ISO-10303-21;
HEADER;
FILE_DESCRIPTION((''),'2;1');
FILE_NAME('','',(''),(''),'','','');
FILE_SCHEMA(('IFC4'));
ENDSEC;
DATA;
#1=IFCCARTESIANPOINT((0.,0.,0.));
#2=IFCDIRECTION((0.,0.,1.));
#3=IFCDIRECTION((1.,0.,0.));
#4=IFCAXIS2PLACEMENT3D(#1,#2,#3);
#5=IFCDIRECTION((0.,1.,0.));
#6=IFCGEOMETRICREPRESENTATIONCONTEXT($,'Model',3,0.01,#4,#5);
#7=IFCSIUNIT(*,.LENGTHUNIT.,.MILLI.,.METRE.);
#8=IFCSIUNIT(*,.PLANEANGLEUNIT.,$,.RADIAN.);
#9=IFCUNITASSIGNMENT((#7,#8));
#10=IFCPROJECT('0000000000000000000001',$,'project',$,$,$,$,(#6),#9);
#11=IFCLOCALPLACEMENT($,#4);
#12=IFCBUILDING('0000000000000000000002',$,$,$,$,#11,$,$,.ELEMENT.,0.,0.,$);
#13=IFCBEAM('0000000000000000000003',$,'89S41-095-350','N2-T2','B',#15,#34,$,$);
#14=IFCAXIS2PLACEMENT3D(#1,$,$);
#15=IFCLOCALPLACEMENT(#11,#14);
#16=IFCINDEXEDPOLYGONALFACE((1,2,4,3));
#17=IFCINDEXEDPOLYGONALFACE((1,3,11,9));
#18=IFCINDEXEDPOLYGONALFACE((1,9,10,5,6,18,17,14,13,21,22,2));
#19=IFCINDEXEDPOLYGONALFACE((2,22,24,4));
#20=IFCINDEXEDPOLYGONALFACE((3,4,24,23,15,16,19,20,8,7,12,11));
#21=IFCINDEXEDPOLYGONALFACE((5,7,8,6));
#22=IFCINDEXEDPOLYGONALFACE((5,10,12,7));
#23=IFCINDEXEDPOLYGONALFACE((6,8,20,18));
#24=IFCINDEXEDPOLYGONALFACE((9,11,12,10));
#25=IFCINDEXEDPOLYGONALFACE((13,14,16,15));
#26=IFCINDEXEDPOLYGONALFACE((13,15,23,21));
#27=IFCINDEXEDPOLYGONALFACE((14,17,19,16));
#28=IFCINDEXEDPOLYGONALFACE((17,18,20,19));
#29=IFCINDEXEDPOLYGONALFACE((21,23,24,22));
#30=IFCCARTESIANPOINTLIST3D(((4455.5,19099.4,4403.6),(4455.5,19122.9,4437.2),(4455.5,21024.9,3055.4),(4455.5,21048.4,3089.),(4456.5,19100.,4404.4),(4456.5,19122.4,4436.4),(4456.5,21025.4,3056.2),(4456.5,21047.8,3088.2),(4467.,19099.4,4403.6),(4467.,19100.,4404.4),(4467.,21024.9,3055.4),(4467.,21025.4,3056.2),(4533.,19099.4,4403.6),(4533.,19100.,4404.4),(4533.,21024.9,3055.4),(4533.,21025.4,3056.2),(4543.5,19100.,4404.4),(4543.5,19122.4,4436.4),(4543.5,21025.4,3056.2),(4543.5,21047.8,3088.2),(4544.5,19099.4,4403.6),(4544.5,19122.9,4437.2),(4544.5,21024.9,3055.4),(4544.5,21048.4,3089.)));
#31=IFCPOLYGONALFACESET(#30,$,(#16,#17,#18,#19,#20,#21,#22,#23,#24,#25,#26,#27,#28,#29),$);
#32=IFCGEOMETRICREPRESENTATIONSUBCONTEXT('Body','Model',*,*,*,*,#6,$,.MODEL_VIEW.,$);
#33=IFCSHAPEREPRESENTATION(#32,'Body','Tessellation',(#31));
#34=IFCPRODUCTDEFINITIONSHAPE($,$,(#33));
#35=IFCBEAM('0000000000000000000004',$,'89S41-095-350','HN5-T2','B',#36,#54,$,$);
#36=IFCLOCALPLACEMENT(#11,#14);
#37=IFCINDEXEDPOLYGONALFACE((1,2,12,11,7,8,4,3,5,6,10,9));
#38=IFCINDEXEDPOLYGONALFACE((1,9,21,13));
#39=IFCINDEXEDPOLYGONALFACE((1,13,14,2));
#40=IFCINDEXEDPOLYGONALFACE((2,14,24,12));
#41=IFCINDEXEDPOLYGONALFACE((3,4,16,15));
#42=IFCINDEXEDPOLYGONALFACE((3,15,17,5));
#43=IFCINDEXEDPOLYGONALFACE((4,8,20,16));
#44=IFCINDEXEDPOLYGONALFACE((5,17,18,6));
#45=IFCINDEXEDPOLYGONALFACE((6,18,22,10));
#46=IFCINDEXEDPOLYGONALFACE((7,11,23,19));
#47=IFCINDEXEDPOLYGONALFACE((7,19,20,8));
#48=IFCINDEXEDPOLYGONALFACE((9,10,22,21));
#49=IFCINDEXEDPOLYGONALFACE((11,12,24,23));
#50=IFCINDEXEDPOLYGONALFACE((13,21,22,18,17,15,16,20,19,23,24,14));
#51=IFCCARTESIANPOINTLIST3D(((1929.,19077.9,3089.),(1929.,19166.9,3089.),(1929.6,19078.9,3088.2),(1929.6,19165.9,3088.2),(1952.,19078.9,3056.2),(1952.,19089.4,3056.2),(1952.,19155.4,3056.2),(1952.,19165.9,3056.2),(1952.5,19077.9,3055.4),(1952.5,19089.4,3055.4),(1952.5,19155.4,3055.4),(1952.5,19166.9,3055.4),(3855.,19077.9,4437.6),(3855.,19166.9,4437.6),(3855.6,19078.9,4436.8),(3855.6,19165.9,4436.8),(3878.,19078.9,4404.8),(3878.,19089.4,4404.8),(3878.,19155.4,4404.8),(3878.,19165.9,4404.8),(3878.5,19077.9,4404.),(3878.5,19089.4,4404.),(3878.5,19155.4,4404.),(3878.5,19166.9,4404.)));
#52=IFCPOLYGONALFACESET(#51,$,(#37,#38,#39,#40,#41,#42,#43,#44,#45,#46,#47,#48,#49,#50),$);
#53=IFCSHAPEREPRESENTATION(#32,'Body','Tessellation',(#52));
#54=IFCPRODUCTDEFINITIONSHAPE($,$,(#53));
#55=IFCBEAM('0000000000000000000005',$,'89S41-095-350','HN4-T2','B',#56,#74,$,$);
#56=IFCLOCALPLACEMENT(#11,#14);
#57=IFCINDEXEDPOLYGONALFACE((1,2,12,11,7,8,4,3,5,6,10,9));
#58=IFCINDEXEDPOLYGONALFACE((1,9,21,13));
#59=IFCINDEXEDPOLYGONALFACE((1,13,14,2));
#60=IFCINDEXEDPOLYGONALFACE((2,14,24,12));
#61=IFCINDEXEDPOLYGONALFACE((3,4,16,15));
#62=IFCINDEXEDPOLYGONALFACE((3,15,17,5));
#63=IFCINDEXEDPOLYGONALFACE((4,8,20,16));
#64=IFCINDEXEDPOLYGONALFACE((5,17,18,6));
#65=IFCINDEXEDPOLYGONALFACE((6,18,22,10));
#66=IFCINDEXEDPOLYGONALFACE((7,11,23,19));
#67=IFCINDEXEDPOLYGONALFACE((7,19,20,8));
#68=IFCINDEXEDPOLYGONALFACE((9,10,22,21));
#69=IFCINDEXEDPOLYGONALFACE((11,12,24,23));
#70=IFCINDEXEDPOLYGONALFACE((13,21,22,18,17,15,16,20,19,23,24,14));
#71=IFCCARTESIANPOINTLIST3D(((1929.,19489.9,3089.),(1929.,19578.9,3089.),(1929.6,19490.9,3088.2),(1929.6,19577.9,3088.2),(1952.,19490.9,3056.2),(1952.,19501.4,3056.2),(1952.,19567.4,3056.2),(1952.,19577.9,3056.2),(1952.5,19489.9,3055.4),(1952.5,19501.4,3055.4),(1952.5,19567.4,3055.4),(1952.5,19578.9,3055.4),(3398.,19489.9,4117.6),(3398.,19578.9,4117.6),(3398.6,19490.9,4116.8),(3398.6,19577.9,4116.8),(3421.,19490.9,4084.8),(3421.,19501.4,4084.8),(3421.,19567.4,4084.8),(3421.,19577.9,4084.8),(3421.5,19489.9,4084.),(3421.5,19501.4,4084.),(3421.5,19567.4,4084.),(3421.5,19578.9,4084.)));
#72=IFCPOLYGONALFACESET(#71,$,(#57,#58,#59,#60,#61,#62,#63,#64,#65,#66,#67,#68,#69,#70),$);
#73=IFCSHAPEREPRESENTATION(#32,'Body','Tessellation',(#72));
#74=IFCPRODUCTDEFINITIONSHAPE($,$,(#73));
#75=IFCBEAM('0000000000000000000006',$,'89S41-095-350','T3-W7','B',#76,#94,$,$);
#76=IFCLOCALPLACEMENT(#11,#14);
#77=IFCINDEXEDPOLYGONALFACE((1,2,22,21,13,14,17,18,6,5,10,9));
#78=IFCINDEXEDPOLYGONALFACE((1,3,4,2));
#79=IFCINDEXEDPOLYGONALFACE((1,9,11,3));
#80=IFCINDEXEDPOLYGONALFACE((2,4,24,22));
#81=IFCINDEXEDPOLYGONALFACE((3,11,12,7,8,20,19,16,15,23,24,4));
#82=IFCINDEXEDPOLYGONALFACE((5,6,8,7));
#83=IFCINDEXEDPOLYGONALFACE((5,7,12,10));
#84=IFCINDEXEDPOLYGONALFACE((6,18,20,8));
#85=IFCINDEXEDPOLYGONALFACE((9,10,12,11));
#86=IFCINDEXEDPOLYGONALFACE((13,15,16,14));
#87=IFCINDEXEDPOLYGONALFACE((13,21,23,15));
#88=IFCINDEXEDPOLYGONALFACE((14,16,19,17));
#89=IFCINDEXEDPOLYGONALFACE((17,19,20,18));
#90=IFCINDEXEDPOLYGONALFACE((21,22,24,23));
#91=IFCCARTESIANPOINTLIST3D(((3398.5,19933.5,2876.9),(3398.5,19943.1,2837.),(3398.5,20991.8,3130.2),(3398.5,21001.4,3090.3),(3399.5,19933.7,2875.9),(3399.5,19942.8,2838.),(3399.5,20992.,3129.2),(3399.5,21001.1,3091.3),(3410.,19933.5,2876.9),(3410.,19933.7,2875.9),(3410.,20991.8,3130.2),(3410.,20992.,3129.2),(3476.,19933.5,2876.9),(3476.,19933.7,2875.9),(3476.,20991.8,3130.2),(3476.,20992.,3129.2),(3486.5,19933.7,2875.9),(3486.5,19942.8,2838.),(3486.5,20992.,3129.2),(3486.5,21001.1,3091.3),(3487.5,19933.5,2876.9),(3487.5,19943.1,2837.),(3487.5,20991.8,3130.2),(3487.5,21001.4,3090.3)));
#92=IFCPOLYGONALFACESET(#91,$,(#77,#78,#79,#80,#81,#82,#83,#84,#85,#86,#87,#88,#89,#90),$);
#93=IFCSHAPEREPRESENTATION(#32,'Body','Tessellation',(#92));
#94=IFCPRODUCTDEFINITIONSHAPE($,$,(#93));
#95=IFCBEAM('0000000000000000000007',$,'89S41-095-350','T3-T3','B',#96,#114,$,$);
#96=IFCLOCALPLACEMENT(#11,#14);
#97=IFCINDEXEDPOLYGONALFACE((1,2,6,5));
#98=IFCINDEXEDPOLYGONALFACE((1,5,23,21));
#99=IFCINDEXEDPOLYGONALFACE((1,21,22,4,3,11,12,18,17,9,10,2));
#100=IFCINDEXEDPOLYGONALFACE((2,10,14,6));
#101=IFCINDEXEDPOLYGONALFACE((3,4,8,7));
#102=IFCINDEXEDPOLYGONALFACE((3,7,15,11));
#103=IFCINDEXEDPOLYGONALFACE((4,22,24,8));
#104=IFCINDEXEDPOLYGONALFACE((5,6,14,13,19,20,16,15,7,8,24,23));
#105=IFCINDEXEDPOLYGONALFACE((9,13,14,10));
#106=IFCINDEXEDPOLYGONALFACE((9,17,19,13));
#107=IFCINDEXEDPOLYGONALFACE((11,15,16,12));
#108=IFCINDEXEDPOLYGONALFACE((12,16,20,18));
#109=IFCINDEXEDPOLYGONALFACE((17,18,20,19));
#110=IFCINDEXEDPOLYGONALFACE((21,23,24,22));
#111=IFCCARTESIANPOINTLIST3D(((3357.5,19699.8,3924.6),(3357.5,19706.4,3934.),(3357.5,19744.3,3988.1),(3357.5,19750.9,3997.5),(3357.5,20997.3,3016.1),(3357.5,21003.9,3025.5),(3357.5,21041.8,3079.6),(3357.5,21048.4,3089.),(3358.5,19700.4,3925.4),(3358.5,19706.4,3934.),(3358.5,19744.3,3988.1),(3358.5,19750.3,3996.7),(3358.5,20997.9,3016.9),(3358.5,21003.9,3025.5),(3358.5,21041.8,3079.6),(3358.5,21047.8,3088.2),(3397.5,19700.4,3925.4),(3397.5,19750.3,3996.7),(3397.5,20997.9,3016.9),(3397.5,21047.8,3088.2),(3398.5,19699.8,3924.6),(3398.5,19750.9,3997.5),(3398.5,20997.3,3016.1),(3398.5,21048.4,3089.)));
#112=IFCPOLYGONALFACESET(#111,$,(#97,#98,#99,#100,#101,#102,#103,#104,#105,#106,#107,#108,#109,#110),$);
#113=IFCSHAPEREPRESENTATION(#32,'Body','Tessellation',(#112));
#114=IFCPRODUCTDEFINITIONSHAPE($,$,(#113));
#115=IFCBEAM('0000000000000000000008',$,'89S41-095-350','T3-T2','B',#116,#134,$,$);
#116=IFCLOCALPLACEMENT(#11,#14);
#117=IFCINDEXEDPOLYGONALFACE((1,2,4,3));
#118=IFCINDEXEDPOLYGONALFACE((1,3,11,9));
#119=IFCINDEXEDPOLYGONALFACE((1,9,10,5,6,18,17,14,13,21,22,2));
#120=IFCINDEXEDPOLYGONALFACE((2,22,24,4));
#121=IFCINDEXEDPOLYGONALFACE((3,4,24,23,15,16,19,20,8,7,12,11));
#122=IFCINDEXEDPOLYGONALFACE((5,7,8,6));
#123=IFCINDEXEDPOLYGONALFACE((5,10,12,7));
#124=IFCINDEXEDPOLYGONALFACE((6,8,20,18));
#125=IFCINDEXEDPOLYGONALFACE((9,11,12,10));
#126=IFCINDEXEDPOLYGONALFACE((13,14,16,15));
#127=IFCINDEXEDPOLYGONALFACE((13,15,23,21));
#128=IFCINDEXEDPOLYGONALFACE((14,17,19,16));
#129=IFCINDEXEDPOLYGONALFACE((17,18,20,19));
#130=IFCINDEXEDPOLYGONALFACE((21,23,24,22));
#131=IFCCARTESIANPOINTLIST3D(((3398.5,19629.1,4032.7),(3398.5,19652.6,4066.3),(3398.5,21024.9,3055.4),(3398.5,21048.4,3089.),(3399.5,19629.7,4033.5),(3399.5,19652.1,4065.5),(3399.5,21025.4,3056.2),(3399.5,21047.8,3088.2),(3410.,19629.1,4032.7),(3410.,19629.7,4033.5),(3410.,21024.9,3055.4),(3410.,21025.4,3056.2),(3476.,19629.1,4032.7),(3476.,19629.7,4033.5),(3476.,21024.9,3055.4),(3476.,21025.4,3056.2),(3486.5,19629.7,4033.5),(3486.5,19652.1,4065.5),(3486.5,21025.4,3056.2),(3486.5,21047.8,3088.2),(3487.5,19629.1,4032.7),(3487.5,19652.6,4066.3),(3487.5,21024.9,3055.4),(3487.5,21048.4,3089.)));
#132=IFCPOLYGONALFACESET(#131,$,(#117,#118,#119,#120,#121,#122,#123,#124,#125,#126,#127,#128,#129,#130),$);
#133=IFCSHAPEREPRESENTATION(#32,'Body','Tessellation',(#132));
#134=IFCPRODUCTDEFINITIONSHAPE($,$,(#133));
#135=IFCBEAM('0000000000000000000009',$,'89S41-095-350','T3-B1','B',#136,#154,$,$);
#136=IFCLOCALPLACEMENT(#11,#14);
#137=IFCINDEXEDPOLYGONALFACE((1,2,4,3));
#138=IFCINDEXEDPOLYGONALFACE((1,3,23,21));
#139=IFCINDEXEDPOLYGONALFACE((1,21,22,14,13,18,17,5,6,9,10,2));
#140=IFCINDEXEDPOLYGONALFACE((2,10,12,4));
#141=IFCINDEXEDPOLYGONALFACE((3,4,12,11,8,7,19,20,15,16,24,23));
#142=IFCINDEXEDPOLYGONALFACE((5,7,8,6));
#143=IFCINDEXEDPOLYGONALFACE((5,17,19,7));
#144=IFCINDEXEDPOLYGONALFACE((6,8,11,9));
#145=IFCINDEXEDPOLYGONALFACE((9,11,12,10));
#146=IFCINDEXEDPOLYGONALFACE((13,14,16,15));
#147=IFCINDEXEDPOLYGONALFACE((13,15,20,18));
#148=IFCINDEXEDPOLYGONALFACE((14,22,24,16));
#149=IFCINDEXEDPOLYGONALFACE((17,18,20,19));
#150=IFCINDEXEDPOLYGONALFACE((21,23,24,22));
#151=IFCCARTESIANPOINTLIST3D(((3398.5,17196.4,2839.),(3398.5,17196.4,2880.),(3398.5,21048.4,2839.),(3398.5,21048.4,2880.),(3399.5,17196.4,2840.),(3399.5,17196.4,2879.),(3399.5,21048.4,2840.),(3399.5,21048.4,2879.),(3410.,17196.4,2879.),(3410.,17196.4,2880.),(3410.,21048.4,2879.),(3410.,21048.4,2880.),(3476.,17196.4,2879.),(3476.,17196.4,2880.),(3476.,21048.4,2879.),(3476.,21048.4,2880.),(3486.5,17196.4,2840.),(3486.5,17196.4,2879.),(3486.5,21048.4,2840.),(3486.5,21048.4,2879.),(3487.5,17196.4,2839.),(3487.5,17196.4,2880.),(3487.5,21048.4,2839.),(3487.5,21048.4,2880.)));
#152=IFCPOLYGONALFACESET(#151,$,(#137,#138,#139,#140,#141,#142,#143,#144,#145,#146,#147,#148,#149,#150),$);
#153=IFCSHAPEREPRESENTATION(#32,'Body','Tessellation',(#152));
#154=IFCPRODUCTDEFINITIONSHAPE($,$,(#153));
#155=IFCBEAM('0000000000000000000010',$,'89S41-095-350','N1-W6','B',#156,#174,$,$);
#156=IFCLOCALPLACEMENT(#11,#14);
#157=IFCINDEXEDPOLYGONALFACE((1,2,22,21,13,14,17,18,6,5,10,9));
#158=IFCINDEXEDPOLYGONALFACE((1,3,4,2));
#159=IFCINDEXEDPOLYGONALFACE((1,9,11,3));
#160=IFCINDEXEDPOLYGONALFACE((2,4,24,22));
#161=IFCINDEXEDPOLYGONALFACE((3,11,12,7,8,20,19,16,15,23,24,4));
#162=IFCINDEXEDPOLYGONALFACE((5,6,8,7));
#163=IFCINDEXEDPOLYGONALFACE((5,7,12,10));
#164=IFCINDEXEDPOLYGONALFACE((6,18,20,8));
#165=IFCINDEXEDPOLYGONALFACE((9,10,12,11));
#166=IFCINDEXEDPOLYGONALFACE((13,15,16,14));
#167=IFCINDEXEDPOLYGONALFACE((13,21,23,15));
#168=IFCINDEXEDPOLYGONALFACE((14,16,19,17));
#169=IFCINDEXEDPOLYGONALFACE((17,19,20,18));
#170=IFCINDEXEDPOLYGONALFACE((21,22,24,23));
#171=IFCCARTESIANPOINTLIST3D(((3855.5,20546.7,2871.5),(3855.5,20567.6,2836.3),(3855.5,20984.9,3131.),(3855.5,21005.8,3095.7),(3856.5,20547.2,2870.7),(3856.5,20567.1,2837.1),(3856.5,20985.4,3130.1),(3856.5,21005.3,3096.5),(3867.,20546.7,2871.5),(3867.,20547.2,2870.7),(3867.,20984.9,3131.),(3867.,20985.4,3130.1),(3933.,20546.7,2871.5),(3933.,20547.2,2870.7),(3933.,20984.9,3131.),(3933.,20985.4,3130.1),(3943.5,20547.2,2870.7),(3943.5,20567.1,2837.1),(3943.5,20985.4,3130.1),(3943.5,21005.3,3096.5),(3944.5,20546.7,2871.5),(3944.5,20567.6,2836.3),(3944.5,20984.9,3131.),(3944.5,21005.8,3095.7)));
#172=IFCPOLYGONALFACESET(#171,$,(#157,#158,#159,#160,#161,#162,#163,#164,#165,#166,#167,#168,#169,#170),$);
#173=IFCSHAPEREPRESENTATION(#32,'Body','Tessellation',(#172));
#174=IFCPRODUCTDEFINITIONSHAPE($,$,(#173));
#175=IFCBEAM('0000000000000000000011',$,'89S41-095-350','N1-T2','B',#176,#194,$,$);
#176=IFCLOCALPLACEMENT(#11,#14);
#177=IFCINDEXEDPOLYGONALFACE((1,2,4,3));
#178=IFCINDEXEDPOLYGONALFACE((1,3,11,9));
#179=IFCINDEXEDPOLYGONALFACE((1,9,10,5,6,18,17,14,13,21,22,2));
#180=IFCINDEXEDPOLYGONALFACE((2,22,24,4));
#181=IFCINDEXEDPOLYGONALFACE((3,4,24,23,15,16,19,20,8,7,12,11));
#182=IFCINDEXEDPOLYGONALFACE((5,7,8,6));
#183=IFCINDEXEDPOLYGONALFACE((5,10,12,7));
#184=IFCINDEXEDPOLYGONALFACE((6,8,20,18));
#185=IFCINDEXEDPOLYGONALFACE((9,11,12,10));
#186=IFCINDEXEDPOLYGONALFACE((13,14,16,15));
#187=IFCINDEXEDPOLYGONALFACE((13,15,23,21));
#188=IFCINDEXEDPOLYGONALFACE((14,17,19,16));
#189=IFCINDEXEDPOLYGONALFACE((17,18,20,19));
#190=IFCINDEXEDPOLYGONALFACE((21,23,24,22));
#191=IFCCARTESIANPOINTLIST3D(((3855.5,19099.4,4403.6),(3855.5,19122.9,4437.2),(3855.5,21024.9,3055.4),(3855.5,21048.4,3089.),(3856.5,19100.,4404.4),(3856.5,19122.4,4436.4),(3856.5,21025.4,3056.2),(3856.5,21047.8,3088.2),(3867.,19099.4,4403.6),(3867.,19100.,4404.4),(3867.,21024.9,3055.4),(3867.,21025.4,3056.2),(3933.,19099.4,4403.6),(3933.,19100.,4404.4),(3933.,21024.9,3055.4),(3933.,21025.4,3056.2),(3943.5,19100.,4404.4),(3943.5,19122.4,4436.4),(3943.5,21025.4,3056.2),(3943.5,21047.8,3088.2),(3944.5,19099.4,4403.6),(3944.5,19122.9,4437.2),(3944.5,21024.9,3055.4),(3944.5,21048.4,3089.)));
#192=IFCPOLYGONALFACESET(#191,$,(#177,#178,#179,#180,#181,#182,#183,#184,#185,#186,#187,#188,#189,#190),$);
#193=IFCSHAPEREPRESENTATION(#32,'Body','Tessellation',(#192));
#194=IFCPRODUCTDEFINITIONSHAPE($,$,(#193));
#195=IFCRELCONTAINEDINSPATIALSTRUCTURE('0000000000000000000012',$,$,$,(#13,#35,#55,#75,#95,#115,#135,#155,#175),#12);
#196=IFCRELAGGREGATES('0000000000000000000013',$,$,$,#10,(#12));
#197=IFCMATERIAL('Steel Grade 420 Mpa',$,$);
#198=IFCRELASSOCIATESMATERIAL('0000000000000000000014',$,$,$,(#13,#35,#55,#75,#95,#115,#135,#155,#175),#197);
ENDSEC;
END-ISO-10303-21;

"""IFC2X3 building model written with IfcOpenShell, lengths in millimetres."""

from ifc_helpers import new_model, si_unit, direction, frame, origin, origin_with_axes, origin_2d_with_axis, place, context, subcontext, project, spatial, c_section, extrude, source, transform, mapped, material, element, save


model = new_model("IFC2X3")

# Units and contexts
model_context = context("Model", 3, precision=0.01, world=origin_with_axes(), true_north=direction((0.0, 1.0, 0.0)))
body_context = subcontext(model_context, "Body", "Model", "MODEL_VIEW")
ifc_project = project(units=[si_unit("LENGTHUNIT", "METRE", prefix="MILLI"), si_unit("PLANEANGLEUNIT", "RADIAN")], contexts=[model_context])

# Building
building_placement = place(None, origin_with_axes())
building = spatial("IfcBuilding", under=ifc_project, at=building_placement, CompositionType="ELEMENT", ElevationOfRefHeight=0.0, ElevationOfTerrain=0.0)

# Shared definitions
ifc_material = material(Name="Steel Grade 420 Mpa")

# Beams
shared_shape_1 = source(origin(), body_context, "Body", "SweptSolid", [
    extrude(c_section(Depth=89.0, Width=41.0, WallThickness=1.0, Girth=11.5, at=origin_2d_with_axis()), origin_with_axes(), (0.0, 0.0, 1.0), 2350.5),
])
beam_1_placement = place(None, frame((4500.0, 19111.2, 4420.4), z_axis=(0.0, 0.819152, -0.573576), x_axis=(0.0, -0.573576, -0.819152)))
element("IfcBeam", 1, at=beam_1_placement, inside=building, material=ifc_material, Name="89S41-095-350", Description="N2-T2", ObjectType="B", context=body_context, shape_type="MappedRepresentation", body=[
    mapped(shared_shape_1, transform((0.0, 0.0, 0.0), scale=1.0)),
])
shared_shape_2 = source(origin(), body_context, "Body", "SweptSolid", [
    extrude(c_section(Depth=89.0, Width=41.0, WallThickness=1.0, Girth=11.5, at=origin_2d_with_axis()), origin_with_axes(), (0.0, 0.0, 1.0), 2351.2),
])
beam_2_placement = place(None, frame((3866.8, 19122.4, 4420.8), z_axis=(-0.819152, 0.0, -0.573576), x_axis=(0.573576, 0.0, -0.819152)))
element("IfcBeam", 2, at=beam_2_placement, inside=building, material=ifc_material, Name="89S41-095-350", Description="HN5-T2", ObjectType="B", context=body_context, shape_type="MappedRepresentation", body=[
    mapped(shared_shape_2, transform((0.0, 0.0, 0.0), scale=1.0)),
])
shared_shape_3 = source(origin(), body_context, "Body", "SweptSolid", [
    extrude(c_section(Depth=89.0, Width=41.0, WallThickness=1.0, Girth=11.5, at=origin_2d_with_axis()), origin_with_axes(), (0.0, 0.0, 1.0), 1793.3),
])
beam_3_placement = place(None, frame((3409.8, 19534.4, 4100.8), z_axis=(-0.819152, 0.0, -0.573576), x_axis=(0.573576, 0.0, -0.819152)))
element("IfcBeam", 3, at=beam_3_placement, inside=building, material=ifc_material, Name="89S41-095-350", Description="HN4-T2", ObjectType="B", context=body_context, shape_type="MappedRepresentation", body=[
    mapped(shared_shape_3, transform((0.0, 0.0, 0.0), scale=1.0)),
])
shared_shape_4 = source(origin(), body_context, "Body", "SweptSolid", [
    extrude(c_section(Depth=89.0, Width=41.0, WallThickness=1.0, Girth=11.5, at=origin_2d_with_axis()), origin_with_axes(), (0.0, 0.0, 1.0), 1088.2),
])
beam_4_placement = place(None, frame((3443.0, 20996.6, 3110.3), z_axis=(0.0, -0.972522, -0.23281), x_axis=(0.0, -0.23281, 0.972522)))
element("IfcBeam", 4, at=beam_4_placement, inside=building, material=ifc_material, Name="89S41-095-350", Description="T3-W7", ObjectType="B", context=body_context, shape_type="MappedRepresentation", body=[
    mapped(shared_shape_4, transform((0.0, 0.0, 0.0), scale=1.0)),
])
shared_shape_5 = source(origin(), body_context, "Body", "SweptSolid", [
    extrude(c_section(Depth=89.0, Width=41.0, WallThickness=1.0, Girth=11.5, at=origin_2d_with_axis()), origin_with_axes(), (0.0, 0.0, 1.0), 1583.9),
])
beam_5_placement = place(None, frame((3378.0, 19725.4, 3961.1), z_axis=(0.0, 0.819152, -0.573576), x_axis=(-1.0, 0.0, 0.0)))
element("IfcBeam", 5, at=beam_5_placement, inside=building, material=ifc_material, Name="89S41-095-350", Description="T3-T3", ObjectType="B", context=body_context, shape_type="MappedRepresentation", body=[
    mapped(shared_shape_5, transform((0.0, 0.0, 0.0), scale=1.0)),
])
shared_shape_6 = source(origin(), body_context, "Body", "SweptSolid", [
    extrude(c_section(Depth=89.0, Width=41.0, WallThickness=1.0, Girth=11.5, at=origin_2d_with_axis()), origin_with_axes(), (0.0, 0.0, 1.0), 1703.9),
])
beam_6_placement = place(None, frame((3443.0, 19640.9, 4049.5), z_axis=(0.0, 0.819152, -0.573576), x_axis=(0.0, -0.573576, -0.819152)))
element("IfcBeam", 6, at=beam_6_placement, inside=building, material=ifc_material, Name="89S41-095-350", Description="T3-T2", ObjectType="B", context=body_context, shape_type="MappedRepresentation", body=[
    mapped(shared_shape_6, transform((0.0, 0.0, 0.0), scale=1.0)),
])
shared_shape_7 = source(origin(), body_context, "Body", "SweptSolid", [
    extrude(c_section(Depth=89.0, Width=41.0, WallThickness=1.0, Girth=11.5, at=origin_2d_with_axis()), origin_with_axes(), (0.0, 0.0, 1.0), 3852.0),
])
beam_7_placement = place(None, frame((3443.0, 21048.4, 2859.5), z_axis=(0.0, -1.0, 0.0), x_axis=(0.0, 0.0, 1.0)))
element("IfcBeam", 7, at=beam_7_placement, inside=building, material=ifc_material, Name="89S41-095-350", Description="T3-B1", ObjectType="B", context=body_context, shape_type="MappedRepresentation", body=[
    mapped(shared_shape_7, transform((0.0, 0.0, 0.0), scale=1.0)),
])
shared_shape_8 = source(origin(), body_context, "Body", "SweptSolid", [
    extrude(c_section(Depth=89.0, Width=41.0, WallThickness=1.0, Girth=11.5, at=origin_2d_with_axis()), origin_with_axes(), (0.0, 0.0, 1.0), 509.2),
])
beam_8_placement = place(None, frame((3900.0, 20995.4, 3113.3), z_axis=(0.0, -0.860497, -0.509455), x_axis=(0.0, -0.509455, 0.860497)))
element("IfcBeam", 8, at=beam_8_placement, inside=building, material=ifc_material, Name="89S41-095-350", Description="N1-W6", ObjectType="B", context=body_context, shape_type="MappedRepresentation", body=[
    mapped(shared_shape_8, transform((0.0, 0.0, 0.0), scale=1.0)),
])
shared_shape_9 = source(origin(), body_context, "Body", "SweptSolid", [
    extrude(c_section(Depth=89.0, Width=41.0, WallThickness=1.0, Girth=11.5, at=origin_2d_with_axis()), origin_with_axes(), (0.0, 0.0, 1.0), 2350.5),
])
beam_9_placement = place(None, frame((3900.0, 19111.2, 4420.4), z_axis=(0.0, 0.819152, -0.573576), x_axis=(0.0, -0.573576, -0.819152)))
element("IfcBeam", 9, at=beam_9_placement, inside=building, material=ifc_material, Name="89S41-095-350", Description="N1-T2", ObjectType="B", context=body_context, shape_type="MappedRepresentation", body=[
    mapped(shared_shape_9, transform((0.0, 0.0, 0.0), scale=1.0)),
])

save(model, "model.ifc")
